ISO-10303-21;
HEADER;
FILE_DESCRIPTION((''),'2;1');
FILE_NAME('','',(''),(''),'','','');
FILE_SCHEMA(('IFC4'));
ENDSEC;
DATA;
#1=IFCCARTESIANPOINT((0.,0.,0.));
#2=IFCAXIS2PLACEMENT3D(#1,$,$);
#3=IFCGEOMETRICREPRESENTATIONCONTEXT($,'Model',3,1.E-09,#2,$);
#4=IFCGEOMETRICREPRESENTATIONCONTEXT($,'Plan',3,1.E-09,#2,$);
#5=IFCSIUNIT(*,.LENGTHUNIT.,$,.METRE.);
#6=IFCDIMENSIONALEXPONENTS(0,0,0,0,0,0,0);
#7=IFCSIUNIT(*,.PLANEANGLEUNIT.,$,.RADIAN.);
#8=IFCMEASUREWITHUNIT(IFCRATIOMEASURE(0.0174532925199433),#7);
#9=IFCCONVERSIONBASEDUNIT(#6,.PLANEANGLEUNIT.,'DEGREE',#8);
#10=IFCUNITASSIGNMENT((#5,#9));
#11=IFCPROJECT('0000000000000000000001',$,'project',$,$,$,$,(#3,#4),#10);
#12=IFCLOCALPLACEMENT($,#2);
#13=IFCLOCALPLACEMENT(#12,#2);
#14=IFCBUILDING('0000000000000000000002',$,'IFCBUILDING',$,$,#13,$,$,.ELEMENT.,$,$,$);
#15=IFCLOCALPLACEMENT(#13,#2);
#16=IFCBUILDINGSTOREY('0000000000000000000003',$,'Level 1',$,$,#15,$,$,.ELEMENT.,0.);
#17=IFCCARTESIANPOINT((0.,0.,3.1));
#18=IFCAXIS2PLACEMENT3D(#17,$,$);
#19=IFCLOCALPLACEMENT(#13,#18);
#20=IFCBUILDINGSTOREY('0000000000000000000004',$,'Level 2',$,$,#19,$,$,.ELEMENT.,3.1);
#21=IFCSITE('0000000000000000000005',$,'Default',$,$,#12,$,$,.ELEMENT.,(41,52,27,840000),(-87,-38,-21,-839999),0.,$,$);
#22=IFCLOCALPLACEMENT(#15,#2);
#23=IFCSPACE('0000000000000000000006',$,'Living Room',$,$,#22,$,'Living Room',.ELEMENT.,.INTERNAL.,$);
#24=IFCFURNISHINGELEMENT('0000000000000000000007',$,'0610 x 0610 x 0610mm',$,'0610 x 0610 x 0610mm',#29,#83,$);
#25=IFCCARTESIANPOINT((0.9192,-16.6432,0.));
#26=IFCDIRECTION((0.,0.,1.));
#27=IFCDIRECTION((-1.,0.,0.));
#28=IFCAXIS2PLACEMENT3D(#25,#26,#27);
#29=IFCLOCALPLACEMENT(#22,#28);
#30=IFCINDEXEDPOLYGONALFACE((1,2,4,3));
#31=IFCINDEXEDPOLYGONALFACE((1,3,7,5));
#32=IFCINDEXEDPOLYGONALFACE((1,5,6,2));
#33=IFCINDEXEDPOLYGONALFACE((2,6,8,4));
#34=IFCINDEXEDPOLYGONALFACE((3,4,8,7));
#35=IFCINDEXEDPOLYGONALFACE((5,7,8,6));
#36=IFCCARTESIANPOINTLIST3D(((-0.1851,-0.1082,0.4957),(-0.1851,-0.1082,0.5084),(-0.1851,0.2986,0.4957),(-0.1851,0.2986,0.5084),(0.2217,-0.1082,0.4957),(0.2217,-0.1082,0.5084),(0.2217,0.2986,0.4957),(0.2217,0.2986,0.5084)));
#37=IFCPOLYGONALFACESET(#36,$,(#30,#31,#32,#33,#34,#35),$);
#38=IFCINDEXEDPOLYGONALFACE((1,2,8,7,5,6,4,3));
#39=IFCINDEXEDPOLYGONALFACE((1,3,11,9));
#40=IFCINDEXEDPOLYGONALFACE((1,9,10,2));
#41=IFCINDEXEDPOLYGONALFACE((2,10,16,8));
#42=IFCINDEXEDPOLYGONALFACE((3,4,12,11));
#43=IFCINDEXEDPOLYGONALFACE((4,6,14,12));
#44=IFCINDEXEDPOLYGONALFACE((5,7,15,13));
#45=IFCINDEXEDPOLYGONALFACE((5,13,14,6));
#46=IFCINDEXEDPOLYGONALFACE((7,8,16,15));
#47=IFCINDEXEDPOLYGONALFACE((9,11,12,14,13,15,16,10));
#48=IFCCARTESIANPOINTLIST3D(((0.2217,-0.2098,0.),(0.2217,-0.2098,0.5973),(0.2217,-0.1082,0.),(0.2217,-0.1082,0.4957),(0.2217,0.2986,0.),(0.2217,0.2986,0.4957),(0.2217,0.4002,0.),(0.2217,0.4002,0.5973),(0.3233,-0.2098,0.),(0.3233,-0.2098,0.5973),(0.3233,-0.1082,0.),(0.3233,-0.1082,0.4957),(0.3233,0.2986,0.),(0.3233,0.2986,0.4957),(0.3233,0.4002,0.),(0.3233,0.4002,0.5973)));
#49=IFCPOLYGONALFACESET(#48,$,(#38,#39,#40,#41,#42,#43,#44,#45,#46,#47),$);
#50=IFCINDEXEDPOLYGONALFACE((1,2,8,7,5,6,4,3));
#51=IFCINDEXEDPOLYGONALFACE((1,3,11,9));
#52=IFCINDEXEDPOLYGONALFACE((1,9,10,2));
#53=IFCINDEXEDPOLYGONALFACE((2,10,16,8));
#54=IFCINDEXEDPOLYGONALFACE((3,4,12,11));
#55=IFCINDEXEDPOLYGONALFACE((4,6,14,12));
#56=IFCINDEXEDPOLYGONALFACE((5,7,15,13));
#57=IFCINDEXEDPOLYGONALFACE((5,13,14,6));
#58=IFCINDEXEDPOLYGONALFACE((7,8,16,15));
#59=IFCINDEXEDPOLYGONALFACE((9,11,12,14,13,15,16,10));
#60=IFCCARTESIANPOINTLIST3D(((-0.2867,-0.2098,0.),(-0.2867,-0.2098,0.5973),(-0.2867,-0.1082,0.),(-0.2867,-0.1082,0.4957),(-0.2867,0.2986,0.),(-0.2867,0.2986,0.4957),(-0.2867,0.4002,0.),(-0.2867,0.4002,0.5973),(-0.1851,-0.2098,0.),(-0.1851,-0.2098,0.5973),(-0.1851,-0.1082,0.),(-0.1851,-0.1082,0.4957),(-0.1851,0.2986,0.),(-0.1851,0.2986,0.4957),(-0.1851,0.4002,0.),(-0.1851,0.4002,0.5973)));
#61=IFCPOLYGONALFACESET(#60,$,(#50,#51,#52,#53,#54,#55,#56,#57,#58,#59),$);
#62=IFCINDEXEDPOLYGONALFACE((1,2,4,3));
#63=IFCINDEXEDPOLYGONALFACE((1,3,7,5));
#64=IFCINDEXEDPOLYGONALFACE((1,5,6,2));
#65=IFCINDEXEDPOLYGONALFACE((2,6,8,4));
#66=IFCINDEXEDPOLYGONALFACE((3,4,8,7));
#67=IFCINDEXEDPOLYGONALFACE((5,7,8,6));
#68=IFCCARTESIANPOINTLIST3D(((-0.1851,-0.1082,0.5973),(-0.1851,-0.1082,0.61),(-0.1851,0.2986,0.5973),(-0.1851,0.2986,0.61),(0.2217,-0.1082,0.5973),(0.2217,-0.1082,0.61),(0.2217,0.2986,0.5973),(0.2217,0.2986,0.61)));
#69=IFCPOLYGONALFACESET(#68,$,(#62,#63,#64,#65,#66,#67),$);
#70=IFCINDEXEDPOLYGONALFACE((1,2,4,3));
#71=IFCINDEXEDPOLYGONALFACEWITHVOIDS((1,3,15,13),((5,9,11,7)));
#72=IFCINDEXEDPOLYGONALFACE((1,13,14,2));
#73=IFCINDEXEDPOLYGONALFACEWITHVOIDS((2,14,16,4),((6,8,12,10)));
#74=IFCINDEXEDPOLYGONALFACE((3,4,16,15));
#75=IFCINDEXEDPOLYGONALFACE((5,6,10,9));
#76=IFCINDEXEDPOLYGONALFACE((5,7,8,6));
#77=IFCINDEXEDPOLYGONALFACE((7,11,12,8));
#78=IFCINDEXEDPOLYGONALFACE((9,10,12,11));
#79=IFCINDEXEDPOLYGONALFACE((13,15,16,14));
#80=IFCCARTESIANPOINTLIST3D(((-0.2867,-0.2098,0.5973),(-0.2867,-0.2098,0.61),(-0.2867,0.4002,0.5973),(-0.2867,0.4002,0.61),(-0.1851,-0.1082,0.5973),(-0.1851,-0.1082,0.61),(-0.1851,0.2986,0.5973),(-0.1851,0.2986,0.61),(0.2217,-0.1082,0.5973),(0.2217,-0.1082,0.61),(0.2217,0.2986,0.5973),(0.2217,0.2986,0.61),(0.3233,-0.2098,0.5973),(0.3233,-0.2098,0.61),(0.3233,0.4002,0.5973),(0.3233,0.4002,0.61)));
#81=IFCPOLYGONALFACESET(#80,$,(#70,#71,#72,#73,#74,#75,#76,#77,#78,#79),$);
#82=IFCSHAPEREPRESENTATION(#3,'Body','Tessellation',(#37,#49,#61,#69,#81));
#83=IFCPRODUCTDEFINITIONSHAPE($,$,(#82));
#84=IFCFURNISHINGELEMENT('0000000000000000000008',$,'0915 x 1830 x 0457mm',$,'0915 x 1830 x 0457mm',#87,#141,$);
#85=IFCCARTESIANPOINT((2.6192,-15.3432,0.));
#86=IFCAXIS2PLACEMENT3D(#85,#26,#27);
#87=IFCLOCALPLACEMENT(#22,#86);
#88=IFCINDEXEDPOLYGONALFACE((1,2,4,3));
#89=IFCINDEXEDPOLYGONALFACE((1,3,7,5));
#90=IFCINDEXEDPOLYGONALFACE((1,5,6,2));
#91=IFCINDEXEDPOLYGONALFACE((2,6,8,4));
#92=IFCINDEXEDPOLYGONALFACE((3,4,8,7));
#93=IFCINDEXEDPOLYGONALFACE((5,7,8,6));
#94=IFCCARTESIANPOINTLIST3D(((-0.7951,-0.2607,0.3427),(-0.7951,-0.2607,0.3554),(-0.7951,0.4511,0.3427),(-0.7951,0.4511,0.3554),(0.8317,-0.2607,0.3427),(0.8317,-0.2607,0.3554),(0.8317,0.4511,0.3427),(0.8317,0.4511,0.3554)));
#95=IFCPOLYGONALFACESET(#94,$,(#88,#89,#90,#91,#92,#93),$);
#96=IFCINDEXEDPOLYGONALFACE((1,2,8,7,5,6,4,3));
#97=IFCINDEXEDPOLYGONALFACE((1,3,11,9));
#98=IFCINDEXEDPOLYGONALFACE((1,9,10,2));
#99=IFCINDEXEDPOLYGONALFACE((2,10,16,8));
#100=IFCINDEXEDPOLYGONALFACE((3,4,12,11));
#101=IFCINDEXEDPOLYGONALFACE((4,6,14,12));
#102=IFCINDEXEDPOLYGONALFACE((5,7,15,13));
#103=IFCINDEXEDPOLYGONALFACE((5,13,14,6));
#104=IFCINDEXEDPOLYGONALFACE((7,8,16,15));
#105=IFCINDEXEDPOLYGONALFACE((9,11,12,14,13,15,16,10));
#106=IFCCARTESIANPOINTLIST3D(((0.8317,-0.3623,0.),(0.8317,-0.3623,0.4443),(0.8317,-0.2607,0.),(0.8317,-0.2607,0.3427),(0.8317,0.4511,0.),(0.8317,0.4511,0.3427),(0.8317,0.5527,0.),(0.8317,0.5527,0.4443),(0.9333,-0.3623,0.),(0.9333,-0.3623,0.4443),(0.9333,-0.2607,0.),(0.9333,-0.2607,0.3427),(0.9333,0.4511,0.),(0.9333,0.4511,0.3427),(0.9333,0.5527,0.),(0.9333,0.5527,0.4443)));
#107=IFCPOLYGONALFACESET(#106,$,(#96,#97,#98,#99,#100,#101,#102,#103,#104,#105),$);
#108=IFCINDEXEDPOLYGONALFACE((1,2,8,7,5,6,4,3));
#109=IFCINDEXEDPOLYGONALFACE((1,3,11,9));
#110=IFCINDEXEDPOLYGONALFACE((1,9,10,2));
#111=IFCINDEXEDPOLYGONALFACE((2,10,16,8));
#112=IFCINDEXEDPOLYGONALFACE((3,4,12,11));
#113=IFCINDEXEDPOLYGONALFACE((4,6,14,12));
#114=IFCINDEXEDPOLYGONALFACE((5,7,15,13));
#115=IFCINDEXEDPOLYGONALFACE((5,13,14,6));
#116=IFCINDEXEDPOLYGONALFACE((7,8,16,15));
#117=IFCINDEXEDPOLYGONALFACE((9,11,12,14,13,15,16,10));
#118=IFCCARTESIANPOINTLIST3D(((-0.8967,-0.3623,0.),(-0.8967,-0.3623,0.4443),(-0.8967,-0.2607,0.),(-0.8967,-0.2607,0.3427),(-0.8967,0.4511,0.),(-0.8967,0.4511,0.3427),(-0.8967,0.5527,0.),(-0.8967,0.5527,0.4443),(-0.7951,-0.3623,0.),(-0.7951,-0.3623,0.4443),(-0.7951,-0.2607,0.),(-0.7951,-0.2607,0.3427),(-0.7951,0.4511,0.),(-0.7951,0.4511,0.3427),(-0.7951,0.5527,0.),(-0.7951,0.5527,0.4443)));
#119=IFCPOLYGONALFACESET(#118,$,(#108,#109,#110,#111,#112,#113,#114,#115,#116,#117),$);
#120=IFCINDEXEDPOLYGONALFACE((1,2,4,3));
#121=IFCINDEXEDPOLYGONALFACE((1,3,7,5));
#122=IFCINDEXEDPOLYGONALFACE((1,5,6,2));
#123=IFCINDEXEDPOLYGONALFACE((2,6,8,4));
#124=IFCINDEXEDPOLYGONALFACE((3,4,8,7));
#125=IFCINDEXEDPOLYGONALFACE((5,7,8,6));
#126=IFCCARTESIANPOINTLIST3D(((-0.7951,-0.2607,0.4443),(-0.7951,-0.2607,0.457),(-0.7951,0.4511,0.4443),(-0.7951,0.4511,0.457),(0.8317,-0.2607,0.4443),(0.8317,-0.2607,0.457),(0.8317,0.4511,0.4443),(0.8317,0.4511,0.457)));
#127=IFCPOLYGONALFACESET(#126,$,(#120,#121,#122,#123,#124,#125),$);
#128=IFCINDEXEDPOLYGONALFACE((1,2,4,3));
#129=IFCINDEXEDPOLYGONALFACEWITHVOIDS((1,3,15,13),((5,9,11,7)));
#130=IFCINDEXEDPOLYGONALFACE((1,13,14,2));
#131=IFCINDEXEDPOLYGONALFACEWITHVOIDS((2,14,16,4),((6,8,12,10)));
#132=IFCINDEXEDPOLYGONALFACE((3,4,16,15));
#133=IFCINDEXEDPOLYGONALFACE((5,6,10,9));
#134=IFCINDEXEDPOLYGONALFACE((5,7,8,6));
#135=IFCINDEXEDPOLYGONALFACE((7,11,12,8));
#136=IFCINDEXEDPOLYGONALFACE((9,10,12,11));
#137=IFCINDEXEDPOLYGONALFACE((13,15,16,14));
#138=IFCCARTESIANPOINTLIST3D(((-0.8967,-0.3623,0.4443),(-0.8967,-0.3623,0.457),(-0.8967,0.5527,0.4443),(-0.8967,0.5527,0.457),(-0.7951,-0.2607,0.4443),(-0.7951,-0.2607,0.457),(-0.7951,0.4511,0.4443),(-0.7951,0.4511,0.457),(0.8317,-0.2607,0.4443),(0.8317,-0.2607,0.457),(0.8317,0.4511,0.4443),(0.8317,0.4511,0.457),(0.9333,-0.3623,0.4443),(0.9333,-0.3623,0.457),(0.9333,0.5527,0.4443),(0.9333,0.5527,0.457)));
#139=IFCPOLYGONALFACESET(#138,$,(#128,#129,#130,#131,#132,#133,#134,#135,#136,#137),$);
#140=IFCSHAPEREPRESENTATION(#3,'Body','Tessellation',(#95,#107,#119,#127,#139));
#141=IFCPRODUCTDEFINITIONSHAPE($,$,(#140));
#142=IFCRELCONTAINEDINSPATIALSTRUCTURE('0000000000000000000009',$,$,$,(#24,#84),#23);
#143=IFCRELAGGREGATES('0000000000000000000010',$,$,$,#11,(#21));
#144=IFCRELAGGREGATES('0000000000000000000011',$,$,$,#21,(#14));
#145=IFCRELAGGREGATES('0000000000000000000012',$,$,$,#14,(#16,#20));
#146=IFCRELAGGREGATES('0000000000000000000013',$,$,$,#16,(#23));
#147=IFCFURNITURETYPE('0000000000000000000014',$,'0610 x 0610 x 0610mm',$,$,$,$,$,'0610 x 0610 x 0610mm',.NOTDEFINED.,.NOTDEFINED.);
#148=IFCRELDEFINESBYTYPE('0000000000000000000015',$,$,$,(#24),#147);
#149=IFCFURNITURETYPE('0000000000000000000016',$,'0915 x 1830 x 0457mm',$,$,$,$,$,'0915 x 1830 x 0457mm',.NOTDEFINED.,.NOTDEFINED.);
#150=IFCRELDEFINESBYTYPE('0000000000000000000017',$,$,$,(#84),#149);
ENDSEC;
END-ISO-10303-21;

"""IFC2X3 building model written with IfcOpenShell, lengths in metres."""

from ifc_helpers import new_model, entity, si_unit, converted_unit, frame, origin, origin_2d_with_axis, place, context, project, spatial, polyline, rectangle, outline, extrude, source, transform, mapped, type_object, type_shapes, element, save


model = new_model("IFC2X3")

# Units and contexts
model_context = context("Model", 3, precision=1e-09, world=origin())
plan_context = context("Plan", 3, precision=1e-09, world=origin())
ifc_project = project(units=[si_unit("LENGTHUNIT", "METRE"), converted_unit("PLANEANGLEUNIT", "DEGREE", entity("IfcRatioMeasure", 0.0174532925199433), si_unit("PLANEANGLEUNIT", "RADIAN"), dimensions=[0, 0, 0, 0, 0, 0, 0])], contexts=[model_context, plan_context])

# Site, building, storey
site_placement = place(None, origin())
site = spatial("IfcSite", under=ifc_project, at=site_placement, Name="Default", CompositionType="ELEMENT", RefLatitude=(41, 52, 27, 840000), RefLongitude=(-87, -38, -21, -839999), RefElevation=0.0)
building_placement = place(site_placement, origin())
building = spatial("IfcBuilding", under=site, at=building_placement, Name="IFCBUILDING", CompositionType="ELEMENT")
storey_1_placement = place(building_placement, origin())
storey_1 = spatial("IfcBuildingStorey", under=building, at=storey_1_placement, Name="Level 1", CompositionType="ELEMENT", Elevation=0.0)

# Shared definitions
storey_2_placement = place(building_placement, frame((0.0, 0.0, 3.1)))
storey_2 = spatial("IfcBuildingStorey", under=building, at=storey_2_placement, Name="Level 2", CompositionType="ELEMENT", Elevation=3.1)

# Shared definitions
space_1_placement = place(storey_1_placement, origin())
space_1 = spatial("IfcSpace", under=storey_1, at=space_1_placement, Name="Living Room", LongName="Living Room", CompositionType="ELEMENT", InteriorOrExteriorSpace="INTERNAL")

# Furnishing elements
furniture_type_1 = type_object("IfcFurnitureType", Name="0610 x 0610 x 0610mm", ElementType="0610 x 0610 x 0610mm", AssemblyPlace="NOTDEFINED")
shared_shape_1 = source(origin(), model_context, "Body", "SweptSolid", [
    extrude(rectangle(XDim=0.4068, YDim=0.4068, at=origin_2d_with_axis()), frame((0.0183, 0.0952, 0.4957), z_axis=(0.0, 0.0, 1.0), x_axis=(-1.0, 0.0, 0.0)), (0.0, 0.0, 1.0), 0.0127),
    extrude(outline(polyline([(-0.2732, -0.305), (0.324, -0.305), (0.324, 0.305), (-0.2732, 0.305), (-0.2732, 0.2034), (0.2225, 0.2034), (0.2225, -0.2034), (-0.2732, -0.2034), (-0.2732, -0.305)])), frame((0.2217, 0.0952, 0.2732), z_axis=(1.0, 0.0, 0.0), x_axis=(0.0, 0.0, 1.0)), (0.0, 0.0, 1.0), 0.1016),
    extrude(outline(polyline([(-0.305, -0.3241), (0.305, -0.3241), (0.305, 0.2733), (0.2034, 0.2733), (0.2034, -0.2224), (-0.2034, -0.2224), (-0.2034, 0.2733), (-0.305, 0.2733), (-0.305, -0.3241)])), frame((-0.2867, 0.0952, 0.2733), z_axis=(1.0, 0.0, 0.0), x_axis=(0.0, -1.0, 0.0)), (0.0, 0.0, 1.0), 0.1016),
    extrude(rectangle(XDim=0.4068, YDim=0.4068, at=origin_2d_with_axis()), frame((0.0183, 0.0952, 0.5973), z_axis=(0.0, 0.0, 1.0), x_axis=(-1.0, 0.0, 0.0)), (0.0, 0.0, 1.0), 0.0127),
    extrude(outline(polyline([(-0.305, -0.305), (0.305, -0.305), (0.305, 0.305), (-0.305, 0.305), (-0.305, -0.305)]), holes=[polyline([(-0.2034, -0.2034), (-0.2034, 0.2034), (0.2034, 0.2034), (0.2034, -0.2034), (-0.2034, -0.2034)])]), frame((0.0183, 0.0952, 0.5973), z_axis=(0.0, 0.0, 1.0), x_axis=(-1.0, 0.0, 0.0)), (0.0, 0.0, 1.0), 0.0127),
])
type_shapes(furniture_type_1, [shared_shape_1])
for number, where, z_axis, x_axis, name in (
    (1, (0.9192, -16.6432, 0.0), (0.0, 0.0, 1.0), (-1.0, 0.0, 0.0), "0610 x 0610 x 0610mm"),
):
    element("IfcFurnishingElement", number, at=place(space_1_placement, frame(where, z_axis=z_axis, x_axis=x_axis)), inside=space_1, type_object=furniture_type_1, Name=name, ObjectType="0610 x 0610 x 0610mm", context=model_context, shape_type="MappedRepresentation", body=[
        mapped(shared_shape_1, transform((0.0, 0.0, 0.0), scale=1.0)),
    ])
furniture_type_2 = type_object("IfcFurnitureType", Name="0915 x 1830 x 0457mm", ElementType="0915 x 1830 x 0457mm", AssemblyPlace="NOTDEFINED")
shared_shape_2 = source(origin(), model_context, "Body", "SweptSolid", [
    extrude(rectangle(XDim=1.6268, YDim=0.7118, at=origin_2d_with_axis()), frame((0.0183, 0.0952, 0.3427), z_axis=(0.0, 0.0, 1.0), x_axis=(-1.0, 0.0, 0.0)), (0.0, 0.0, 1.0), 0.0127),
    extrude(outline(polyline([(-0.1967, -0.4575), (0.2475, -0.4575), (0.2475, 0.4575), (-0.1967, 0.4575), (-0.1967, 0.3559), (0.146, 0.3559), (0.146, -0.3559), (-0.1967, -0.3559), (-0.1967, -0.4575)])), frame((0.8317, 0.0952, 0.1967), z_axis=(1.0, 0.0, 0.0), x_axis=(0.0, 0.0, 1.0)), (0.0, 0.0, 1.0), 0.1016),
    extrude(outline(polyline([(-0.4575, -0.2476), (0.4575, -0.2476), (0.4575, 0.1968), (0.3559, 0.1968), (0.3559, -0.1459), (-0.3559, -0.1459), (-0.3559, 0.1968), (-0.4575, 0.1968), (-0.4575, -0.2476)])), frame((-0.8967, 0.0952, 0.1968), z_axis=(1.0, 0.0, 0.0), x_axis=(0.0, -1.0, 0.0)), (0.0, 0.0, 1.0), 0.1016),
    extrude(rectangle(XDim=1.6268, YDim=0.7118, at=origin_2d_with_axis()), frame((0.0183, 0.0952, 0.4443), z_axis=(0.0, 0.0, 1.0), x_axis=(-1.0, 0.0, 0.0)), (0.0, 0.0, 1.0), 0.0127),
    extrude(outline(polyline([(-0.915, -0.4575), (0.915, -0.4575), (0.915, 0.4575), (-0.915, 0.4575), (-0.915, -0.4575)]), holes=[polyline([(-0.8134, -0.3559), (-0.8134, 0.3559), (0.8134, 0.3559), (0.8134, -0.3559), (-0.8134, -0.3559)])]), frame((0.0183, 0.0952, 0.4443), z_axis=(0.0, 0.0, 1.0), x_axis=(-1.0, 0.0, 0.0)), (0.0, 0.0, 1.0), 0.0127),
])
type_shapes(furniture_type_2, [shared_shape_2])
furnishing_1_placement = place(space_1_placement, frame((2.6192, -15.3432, 0.0), z_axis=(0.0, 0.0, 1.0), x_axis=(-1.0, 0.0, 0.0)))
element("IfcFurnishingElement", 2, at=furnishing_1_placement, inside=space_1, type_object=furniture_type_2, Name="0915 x 1830 x 0457mm", ObjectType="0915 x 1830 x 0457mm", context=model_context, shape_type="MappedRepresentation", body=[
    mapped(shared_shape_2, transform((0.0, 0.0, 0.0), scale=1.0)),
])

save(model, "model.ifc")
